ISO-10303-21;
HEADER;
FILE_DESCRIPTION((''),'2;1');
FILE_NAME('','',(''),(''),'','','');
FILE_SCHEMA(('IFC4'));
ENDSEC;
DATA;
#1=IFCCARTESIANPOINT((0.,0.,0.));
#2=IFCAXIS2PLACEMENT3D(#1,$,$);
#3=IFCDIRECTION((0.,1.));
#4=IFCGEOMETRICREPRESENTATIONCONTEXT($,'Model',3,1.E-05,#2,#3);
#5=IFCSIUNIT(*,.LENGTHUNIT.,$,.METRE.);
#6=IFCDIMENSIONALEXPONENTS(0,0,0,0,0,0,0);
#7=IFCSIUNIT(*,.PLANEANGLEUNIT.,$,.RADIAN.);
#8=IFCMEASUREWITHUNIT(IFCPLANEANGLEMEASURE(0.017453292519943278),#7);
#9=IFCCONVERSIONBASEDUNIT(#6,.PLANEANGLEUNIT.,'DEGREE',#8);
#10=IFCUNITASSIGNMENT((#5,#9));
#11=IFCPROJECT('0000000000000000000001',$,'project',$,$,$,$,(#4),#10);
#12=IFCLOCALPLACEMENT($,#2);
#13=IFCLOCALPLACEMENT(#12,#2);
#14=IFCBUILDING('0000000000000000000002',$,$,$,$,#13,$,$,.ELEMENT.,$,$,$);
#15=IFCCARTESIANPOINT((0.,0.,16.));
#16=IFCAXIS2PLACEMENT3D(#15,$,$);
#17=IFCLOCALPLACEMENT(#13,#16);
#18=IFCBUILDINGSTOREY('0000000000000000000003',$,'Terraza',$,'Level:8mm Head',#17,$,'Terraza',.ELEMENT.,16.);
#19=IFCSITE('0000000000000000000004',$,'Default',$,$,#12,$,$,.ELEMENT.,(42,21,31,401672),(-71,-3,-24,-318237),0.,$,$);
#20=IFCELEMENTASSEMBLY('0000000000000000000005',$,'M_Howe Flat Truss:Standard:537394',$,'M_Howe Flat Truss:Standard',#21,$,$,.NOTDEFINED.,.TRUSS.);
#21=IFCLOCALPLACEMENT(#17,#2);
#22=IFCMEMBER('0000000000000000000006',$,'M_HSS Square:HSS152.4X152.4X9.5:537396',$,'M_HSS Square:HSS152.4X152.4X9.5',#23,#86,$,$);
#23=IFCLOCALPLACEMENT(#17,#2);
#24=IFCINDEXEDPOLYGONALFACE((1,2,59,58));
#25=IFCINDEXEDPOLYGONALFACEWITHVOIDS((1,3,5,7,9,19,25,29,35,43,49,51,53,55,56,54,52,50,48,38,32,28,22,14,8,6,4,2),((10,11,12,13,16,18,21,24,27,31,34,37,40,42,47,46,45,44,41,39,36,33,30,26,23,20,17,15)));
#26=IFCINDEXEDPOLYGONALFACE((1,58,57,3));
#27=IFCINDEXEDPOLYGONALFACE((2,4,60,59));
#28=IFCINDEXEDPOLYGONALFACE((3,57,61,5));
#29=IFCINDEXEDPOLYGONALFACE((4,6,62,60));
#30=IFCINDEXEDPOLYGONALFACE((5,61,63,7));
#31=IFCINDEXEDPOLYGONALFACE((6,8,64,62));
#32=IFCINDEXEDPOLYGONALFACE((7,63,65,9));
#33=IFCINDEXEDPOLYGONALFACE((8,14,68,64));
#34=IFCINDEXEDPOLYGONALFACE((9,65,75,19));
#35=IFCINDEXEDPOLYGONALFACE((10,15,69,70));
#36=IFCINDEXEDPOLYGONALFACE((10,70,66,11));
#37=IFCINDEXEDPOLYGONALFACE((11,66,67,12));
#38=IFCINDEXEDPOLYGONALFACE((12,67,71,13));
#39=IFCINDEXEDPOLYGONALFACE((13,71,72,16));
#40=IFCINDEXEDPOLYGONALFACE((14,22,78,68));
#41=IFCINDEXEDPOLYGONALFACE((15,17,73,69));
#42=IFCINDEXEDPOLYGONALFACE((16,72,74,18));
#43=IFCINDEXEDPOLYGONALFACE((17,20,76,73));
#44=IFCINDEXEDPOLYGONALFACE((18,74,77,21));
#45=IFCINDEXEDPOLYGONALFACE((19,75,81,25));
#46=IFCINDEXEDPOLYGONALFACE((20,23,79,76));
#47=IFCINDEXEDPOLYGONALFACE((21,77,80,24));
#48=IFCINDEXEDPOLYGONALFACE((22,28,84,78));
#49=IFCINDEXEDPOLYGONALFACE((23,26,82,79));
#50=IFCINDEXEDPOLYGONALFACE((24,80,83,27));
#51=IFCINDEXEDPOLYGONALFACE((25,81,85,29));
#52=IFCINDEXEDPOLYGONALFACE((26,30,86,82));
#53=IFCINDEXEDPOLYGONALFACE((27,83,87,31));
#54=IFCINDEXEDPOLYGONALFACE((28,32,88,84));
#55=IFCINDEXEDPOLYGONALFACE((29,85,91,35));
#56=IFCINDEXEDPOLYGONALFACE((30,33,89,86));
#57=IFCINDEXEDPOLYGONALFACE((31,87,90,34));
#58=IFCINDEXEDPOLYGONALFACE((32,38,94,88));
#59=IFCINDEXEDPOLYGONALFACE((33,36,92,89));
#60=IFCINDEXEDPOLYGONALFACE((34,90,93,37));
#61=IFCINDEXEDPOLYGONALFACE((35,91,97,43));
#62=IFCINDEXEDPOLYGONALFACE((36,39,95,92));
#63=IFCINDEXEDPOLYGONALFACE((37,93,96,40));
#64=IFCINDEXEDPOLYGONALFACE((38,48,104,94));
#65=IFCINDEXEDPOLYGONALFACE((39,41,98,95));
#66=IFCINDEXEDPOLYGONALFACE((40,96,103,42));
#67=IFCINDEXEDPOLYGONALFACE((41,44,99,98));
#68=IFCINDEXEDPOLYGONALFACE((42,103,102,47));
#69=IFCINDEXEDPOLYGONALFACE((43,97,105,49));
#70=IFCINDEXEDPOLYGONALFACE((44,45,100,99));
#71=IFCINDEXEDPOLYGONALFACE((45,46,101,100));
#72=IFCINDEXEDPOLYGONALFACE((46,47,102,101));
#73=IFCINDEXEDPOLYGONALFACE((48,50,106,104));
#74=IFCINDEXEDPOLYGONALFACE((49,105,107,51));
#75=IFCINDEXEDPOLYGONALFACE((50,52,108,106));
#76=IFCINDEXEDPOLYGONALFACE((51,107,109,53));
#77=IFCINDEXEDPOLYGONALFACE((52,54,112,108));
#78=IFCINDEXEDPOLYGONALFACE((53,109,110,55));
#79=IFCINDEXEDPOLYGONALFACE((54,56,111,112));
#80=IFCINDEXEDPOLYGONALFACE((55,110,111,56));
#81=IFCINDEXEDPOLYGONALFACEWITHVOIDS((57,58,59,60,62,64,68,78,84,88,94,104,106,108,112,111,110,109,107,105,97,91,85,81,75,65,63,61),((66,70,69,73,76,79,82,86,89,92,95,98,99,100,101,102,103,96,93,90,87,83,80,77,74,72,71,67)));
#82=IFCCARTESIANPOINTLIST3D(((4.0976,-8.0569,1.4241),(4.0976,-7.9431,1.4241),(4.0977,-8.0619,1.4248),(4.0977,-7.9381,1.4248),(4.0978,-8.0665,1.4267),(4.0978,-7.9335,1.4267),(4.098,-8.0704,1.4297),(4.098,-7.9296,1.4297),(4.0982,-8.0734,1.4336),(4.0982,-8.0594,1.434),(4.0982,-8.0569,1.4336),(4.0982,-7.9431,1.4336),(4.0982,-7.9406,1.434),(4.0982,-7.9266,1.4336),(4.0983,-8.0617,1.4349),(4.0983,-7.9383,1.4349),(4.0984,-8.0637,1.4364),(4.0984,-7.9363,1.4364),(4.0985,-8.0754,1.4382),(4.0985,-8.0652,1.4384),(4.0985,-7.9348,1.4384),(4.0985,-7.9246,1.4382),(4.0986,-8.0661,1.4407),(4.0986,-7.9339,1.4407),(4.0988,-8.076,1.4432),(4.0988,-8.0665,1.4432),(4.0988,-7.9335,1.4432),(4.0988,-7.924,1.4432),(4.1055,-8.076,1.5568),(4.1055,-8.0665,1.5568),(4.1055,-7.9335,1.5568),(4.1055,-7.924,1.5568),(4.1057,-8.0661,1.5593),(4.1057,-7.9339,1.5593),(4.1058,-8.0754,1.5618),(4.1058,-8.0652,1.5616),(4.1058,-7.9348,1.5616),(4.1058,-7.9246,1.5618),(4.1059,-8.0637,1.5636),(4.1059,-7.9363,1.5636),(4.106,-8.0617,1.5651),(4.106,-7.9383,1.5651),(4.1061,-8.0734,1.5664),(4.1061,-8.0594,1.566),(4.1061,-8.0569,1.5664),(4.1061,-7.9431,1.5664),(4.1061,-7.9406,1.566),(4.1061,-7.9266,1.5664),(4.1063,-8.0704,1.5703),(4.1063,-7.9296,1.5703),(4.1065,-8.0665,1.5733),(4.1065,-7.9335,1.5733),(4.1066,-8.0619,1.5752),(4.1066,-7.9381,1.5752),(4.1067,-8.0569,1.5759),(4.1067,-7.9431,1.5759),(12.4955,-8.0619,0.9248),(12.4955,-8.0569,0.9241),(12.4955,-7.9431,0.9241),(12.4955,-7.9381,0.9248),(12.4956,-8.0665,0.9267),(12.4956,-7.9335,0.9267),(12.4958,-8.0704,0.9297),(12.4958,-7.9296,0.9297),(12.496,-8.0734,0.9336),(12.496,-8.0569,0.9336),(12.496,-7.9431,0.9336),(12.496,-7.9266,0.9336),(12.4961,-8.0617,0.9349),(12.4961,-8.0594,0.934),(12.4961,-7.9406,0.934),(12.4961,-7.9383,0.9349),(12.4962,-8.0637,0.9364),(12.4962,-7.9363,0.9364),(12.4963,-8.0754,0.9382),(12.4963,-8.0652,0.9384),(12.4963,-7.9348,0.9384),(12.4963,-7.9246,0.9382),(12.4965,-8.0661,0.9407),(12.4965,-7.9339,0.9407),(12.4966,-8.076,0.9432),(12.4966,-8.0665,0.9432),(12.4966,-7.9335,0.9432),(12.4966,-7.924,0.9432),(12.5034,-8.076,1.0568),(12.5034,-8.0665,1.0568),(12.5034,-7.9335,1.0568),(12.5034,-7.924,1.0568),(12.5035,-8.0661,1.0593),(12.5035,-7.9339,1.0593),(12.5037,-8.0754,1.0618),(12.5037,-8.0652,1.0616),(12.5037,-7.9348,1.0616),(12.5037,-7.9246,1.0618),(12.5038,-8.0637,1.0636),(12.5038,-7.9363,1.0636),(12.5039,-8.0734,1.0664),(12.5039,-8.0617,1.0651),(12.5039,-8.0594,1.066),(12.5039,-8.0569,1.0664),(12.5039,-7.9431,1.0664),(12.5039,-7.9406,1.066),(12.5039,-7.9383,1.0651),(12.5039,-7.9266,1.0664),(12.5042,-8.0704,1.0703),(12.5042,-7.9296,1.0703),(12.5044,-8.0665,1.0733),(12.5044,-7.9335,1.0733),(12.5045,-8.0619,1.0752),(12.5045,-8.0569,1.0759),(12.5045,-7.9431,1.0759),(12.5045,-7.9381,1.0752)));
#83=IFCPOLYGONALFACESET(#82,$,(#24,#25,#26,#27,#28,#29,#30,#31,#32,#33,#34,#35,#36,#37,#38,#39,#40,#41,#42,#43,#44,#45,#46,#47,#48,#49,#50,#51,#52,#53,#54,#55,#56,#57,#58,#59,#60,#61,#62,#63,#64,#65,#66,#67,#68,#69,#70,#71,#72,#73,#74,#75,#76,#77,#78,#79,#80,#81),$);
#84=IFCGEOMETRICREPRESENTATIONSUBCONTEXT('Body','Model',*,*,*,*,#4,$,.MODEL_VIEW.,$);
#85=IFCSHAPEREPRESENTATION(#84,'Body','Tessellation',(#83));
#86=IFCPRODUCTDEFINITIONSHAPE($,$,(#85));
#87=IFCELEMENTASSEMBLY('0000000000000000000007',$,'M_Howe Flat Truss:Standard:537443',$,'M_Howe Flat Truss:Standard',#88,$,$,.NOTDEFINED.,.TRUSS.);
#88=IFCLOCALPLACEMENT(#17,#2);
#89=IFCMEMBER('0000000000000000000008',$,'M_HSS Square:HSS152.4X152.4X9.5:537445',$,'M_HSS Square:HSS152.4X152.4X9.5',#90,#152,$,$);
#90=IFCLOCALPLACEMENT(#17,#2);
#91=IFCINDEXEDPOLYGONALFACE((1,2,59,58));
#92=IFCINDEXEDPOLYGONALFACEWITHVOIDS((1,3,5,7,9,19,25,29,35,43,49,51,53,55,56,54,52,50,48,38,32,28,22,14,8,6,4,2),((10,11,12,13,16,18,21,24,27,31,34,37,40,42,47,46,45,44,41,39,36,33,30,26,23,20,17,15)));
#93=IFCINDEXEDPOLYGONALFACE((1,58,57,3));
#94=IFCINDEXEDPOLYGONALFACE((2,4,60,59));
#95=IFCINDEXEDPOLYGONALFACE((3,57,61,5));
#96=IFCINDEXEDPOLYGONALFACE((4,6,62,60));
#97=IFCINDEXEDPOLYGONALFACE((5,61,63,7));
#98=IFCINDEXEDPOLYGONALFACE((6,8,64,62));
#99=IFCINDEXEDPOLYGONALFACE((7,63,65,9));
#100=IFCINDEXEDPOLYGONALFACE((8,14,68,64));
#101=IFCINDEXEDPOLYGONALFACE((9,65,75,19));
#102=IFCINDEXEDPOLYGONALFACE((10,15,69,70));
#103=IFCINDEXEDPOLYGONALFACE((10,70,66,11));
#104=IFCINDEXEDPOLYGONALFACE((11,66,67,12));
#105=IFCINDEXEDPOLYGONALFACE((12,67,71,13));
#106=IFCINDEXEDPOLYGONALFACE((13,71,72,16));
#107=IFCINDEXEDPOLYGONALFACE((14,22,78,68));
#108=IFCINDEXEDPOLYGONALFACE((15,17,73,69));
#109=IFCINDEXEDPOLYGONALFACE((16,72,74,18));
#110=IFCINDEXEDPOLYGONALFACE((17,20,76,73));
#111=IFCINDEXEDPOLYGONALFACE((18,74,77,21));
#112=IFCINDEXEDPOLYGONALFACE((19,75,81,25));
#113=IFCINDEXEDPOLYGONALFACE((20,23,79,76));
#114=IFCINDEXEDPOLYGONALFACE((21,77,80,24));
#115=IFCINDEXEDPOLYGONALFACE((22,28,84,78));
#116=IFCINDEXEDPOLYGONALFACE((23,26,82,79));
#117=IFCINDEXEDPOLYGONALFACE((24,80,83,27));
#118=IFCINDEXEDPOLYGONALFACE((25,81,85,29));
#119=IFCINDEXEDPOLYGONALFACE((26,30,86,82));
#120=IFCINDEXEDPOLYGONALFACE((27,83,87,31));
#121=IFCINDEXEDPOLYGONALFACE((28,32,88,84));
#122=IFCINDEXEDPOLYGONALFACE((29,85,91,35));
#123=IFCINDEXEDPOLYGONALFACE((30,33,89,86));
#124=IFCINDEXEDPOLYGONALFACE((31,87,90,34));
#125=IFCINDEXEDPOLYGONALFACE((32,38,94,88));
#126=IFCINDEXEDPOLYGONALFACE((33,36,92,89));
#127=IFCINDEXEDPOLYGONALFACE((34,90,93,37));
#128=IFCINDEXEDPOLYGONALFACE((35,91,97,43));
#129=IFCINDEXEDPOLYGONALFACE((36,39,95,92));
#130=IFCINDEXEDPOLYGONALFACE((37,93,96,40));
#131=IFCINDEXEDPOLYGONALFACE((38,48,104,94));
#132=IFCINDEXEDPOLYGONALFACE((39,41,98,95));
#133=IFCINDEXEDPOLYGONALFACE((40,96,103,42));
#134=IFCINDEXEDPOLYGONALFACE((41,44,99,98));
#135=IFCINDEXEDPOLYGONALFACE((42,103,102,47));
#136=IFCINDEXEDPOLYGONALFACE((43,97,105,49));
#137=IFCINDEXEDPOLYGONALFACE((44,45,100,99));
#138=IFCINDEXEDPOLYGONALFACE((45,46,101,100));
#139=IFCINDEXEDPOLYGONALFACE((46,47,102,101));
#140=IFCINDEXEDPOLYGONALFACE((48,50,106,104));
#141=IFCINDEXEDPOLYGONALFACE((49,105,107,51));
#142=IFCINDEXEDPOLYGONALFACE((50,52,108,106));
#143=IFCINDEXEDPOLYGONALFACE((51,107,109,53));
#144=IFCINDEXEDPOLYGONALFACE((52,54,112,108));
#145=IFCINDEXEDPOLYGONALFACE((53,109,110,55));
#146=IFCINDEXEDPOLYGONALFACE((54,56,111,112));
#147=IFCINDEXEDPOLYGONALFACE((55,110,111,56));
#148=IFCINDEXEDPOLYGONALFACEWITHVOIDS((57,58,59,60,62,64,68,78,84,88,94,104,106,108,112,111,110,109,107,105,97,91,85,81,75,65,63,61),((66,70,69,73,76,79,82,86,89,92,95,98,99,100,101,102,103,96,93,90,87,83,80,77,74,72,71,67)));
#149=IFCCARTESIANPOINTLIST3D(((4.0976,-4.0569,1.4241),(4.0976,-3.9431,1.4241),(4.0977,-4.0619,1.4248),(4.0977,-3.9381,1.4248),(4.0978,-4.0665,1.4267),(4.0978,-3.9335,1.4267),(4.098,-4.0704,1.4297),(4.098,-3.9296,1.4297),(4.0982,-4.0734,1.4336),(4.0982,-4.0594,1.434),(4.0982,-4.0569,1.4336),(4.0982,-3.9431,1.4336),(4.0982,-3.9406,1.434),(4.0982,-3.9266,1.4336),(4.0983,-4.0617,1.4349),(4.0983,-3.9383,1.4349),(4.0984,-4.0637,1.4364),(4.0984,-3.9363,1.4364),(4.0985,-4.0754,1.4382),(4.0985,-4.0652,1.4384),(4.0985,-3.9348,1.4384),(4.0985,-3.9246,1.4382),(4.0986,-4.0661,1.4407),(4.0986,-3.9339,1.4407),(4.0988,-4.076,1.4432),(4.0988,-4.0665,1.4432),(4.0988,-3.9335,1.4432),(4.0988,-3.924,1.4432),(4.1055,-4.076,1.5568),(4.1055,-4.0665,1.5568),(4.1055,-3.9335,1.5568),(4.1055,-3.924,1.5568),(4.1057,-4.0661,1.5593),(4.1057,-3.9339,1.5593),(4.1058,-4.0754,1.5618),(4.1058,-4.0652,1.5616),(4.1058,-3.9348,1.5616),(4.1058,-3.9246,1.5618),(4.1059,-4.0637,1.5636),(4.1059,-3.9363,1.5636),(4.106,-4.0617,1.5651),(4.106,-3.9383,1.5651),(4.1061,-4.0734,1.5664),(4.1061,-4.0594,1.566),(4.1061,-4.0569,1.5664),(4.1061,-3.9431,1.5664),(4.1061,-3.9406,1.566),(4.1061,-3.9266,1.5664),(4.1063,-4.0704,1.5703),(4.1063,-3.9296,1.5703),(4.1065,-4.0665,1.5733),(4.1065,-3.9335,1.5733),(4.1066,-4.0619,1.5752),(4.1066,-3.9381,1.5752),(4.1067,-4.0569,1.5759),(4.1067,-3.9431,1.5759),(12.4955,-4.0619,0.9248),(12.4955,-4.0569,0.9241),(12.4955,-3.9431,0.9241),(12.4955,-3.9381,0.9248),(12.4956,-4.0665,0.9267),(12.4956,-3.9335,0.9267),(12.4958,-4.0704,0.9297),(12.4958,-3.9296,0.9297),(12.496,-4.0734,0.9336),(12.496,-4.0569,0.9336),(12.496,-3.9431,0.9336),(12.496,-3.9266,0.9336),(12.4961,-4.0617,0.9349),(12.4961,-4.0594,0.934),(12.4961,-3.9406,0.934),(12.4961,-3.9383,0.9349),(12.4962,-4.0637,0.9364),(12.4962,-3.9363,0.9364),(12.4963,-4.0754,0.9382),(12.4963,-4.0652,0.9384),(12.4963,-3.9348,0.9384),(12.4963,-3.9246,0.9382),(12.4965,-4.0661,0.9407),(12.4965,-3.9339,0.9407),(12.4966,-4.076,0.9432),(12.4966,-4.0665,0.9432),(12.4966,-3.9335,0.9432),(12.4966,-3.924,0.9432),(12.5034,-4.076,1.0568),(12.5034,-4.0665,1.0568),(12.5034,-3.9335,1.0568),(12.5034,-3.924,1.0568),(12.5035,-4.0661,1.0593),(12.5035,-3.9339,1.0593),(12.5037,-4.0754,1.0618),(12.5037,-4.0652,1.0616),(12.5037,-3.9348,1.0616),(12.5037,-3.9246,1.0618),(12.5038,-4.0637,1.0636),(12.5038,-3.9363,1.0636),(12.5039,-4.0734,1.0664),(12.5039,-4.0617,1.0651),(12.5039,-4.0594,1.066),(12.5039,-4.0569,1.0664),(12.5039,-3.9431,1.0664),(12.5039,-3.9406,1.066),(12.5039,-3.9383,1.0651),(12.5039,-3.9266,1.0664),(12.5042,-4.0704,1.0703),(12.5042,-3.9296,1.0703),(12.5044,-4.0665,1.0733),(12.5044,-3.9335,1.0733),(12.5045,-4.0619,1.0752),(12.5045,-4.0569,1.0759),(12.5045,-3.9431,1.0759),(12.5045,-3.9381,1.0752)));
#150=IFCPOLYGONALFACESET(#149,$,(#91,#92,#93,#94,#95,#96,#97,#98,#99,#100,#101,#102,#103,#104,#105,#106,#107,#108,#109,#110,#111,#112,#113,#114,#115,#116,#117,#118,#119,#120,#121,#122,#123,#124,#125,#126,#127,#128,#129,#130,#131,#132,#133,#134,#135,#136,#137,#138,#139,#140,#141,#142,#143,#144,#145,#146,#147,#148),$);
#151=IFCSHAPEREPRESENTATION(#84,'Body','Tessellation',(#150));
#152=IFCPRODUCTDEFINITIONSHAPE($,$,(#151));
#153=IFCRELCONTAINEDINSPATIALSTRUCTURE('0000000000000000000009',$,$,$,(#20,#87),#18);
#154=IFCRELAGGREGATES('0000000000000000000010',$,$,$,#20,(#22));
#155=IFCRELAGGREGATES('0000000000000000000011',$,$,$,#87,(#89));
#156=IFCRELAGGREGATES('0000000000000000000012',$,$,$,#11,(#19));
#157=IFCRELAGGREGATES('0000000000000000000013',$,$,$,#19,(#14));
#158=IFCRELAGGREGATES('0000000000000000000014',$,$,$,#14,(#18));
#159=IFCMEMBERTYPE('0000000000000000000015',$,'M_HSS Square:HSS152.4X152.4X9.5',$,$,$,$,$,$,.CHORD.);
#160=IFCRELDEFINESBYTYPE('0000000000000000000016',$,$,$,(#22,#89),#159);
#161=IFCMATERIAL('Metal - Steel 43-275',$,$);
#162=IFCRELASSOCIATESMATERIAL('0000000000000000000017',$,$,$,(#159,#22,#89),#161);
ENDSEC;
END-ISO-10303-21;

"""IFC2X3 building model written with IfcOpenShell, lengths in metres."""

from ifc_helpers import new_model, entity, si_unit, converted_unit, direction, frame, frame_2d, origin, place, context, subcontext, project, spatial, polyline, circle_curve, parameter, trimmed, segment, composite_curve, outline, extrude, source, transform, mapped, material, type_object, type_shapes, element, aggregate, save


model = new_model("IFC2X3")

# Units and contexts
model_context = context("Model", 3, precision=1e-05, world=origin(), true_north=direction((0.0, 1.0)))
body_context = subcontext(model_context, "Body", "Model", "MODEL_VIEW")
ifc_project = project(units=[si_unit("LENGTHUNIT", "METRE"), converted_unit("PLANEANGLEUNIT", "DEGREE", entity("IfcPlaneAngleMeasure", 0.017453292519943278), si_unit("PLANEANGLEUNIT", "RADIAN"), dimensions=[0, 0, 0, 0, 0, 0, 0])], contexts=[model_context])

# Site, building, storey
site_placement = place(None, origin())
site = spatial("IfcSite", under=ifc_project, at=site_placement, Name="Default", CompositionType="ELEMENT", RefLatitude=(42, 21, 31, 401672), RefLongitude=(-71, -3, -24, -318237), RefElevation=0.0)
building_placement = place(site_placement, origin())
building = spatial("IfcBuilding", under=site, at=building_placement, CompositionType="ELEMENT")
storey_placement = place(building_placement, frame((0.0, 0.0, 16.0)))
storey = spatial("IfcBuildingStorey", under=building, at=storey_placement, Name="Terraza", ObjectType="Level:8mm Head", LongName="Terraza", CompositionType="ELEMENT", Elevation=16.0)

# Element assemblies, members
assembly_1_placement = place(storey_placement, origin())
assembly_1 = element("IfcElementAssembly", 1, at=assembly_1_placement, inside=storey, Name="M_Howe Flat Truss:Standard:537394", ObjectType="M_Howe Flat Truss:Standard", AssemblyPlace="NOTDEFINED", PredefinedType="TRUSS")
ifc_material_1 = material(Name="Metal - Steel 43-275")
member_type_1 = type_object("IfcMemberType", Name="M_HSS Square:HSS152.4X152.4X9.5", PredefinedType="CHORD", material=ifc_material_1)
shared_shape_1 = source(origin(), body_context, "Body", "SweptSolid", [
    extrude(outline(composite_curve([segment(polyline([(-0.0569, -0.076), (0.0569, -0.076)]), True, "CONTINUOUS"), segment(trimmed(circle_curve(frame_2d((0.0569, -0.0569), x_axis=(0.0, 1.0)), 0.0191), [parameter(180.0)], [parameter(270.0)], True, "PARAMETER"), True, "CONTINUOUS"), segment(polyline([(0.076, -0.0569), (0.076, 0.0569)]), True, "CONTINUOUS"), segment(trimmed(circle_curve(frame_2d((0.0569, 0.0569), x_axis=(0.0, 1.0)), 0.0191), [parameter(270.0)], [parameter(0.0)], True, "PARAMETER"), True, "CONTINUOUS"), segment(polyline([(0.0569, 0.076), (-0.0569, 0.076)]), True, "CONTINUOUS"), segment(trimmed(circle_curve(frame_2d((-0.0569, 0.0569), x_axis=(0.0, 1.0)), 0.0191), [parameter(0.0)], [parameter(90.0)], True, "PARAMETER"), True, "CONTINUOUS"), segment(polyline([(-0.076, 0.0569), (-0.076, -0.0569)]), True, "CONTINUOUS"), segment(trimmed(circle_curve(frame_2d((-0.0569, -0.0569), x_axis=(0.0, 1.0)), 0.0191), [parameter(90.0)], [parameter(180.0)], True, "PARAMETER"), True, "CONTINUOUS")], self_intersect=False), holes=[composite_curve([segment(trimmed(circle_curve(frame_2d((-0.0569, 0.0569), x_axis=(0.0, 1.0)), 0.0095), [parameter(360.0)], [parameter(90.0)], True, "PARAMETER"), False, "CONTINUOUS"), segment(polyline([(-0.0569, 0.0665), (0.0569, 0.0665)]), True, "CONTINUOUS"), segment(trimmed(circle_curve(frame_2d((0.0569, 0.0569), x_axis=(0.0, 1.0)), 0.0095), [parameter(270.0)], [parameter(360.0)], True, "PARAMETER"), False, "CONTINUOUS"), segment(polyline([(0.0665, 0.0569), (0.0665, -0.0569)]), True, "CONTINUOUS"), segment(trimmed(circle_curve(frame_2d((0.0569, -0.0569), x_axis=(0.0, 1.0)), 0.0095), [parameter(180.0)], [parameter(270.0)], True, "PARAMETER"), False, "CONTINUOUS"), segment(polyline([(0.0569, -0.0665), (-0.0569, -0.0665)]), True, "CONTINUOUS"), segment(trimmed(circle_curve(frame_2d((-0.0569, -0.0569), x_axis=(0.0, 1.0)), 0.0095), [parameter(90.0)], [parameter(180.0)], True, "PARAMETER"), False, "CONTINUOUS"), segment(polyline([(-0.0665, -0.0569), (-0.0665, 0.0569)]), True, "CONTINUOUS")], self_intersect=False)]), frame((-4.2064, 0.0, 0.0), z_axis=(1.0, 0.0, 0.0), x_axis=(0.0, 0.0, -1.0)), (0.0, 0.0, 1.0), 8.4127),
])
type_shapes(member_type_1, [shared_shape_1])
member_1_placement = place(assembly_1_placement, frame((8.3011, -8.0, 1.25), z_axis=(0.059434, 0.0, 0.998232), x_axis=(0.998232, 0.0, -0.059434)))
member_1 = element("IfcMember", 2, at=member_1_placement, type_object=member_type_1, material=ifc_material_1, Name="M_HSS Square:HSS152.4X152.4X9.5:537396", ObjectType="M_HSS Square:HSS152.4X152.4X9.5", context=body_context, shape_type="MappedRepresentation", body=[
    mapped(shared_shape_1, transform((0.0, 0.0, 0.0), scale=1.0)),
])
aggregate(assembly_1, [member_1])
assembly_2_placement = place(storey_placement, origin())
assembly_2 = element("IfcElementAssembly", 3, at=assembly_2_placement, inside=storey, Name="M_Howe Flat Truss:Standard:537443", ObjectType="M_Howe Flat Truss:Standard", AssemblyPlace="NOTDEFINED", PredefinedType="TRUSS")
member_2_placement = place(assembly_2_placement, frame((8.3011, -4.0, 1.25), z_axis=(0.059434, 0.0, 0.998232), x_axis=(0.998232, 0.0, -0.059434)))
member_2 = element("IfcMember", 4, at=member_2_placement, type_object=member_type_1, material=ifc_material_1, Name="M_HSS Square:HSS152.4X152.4X9.5:537445", ObjectType="M_HSS Square:HSS152.4X152.4X9.5", context=body_context, shape_type="MappedRepresentation", body=[
    mapped(shared_shape_1, transform((0.0, 0.0, 0.0), scale=1.0)),
])

aggregate(assembly_2, [member_2])

save(model, "model.ifc")
